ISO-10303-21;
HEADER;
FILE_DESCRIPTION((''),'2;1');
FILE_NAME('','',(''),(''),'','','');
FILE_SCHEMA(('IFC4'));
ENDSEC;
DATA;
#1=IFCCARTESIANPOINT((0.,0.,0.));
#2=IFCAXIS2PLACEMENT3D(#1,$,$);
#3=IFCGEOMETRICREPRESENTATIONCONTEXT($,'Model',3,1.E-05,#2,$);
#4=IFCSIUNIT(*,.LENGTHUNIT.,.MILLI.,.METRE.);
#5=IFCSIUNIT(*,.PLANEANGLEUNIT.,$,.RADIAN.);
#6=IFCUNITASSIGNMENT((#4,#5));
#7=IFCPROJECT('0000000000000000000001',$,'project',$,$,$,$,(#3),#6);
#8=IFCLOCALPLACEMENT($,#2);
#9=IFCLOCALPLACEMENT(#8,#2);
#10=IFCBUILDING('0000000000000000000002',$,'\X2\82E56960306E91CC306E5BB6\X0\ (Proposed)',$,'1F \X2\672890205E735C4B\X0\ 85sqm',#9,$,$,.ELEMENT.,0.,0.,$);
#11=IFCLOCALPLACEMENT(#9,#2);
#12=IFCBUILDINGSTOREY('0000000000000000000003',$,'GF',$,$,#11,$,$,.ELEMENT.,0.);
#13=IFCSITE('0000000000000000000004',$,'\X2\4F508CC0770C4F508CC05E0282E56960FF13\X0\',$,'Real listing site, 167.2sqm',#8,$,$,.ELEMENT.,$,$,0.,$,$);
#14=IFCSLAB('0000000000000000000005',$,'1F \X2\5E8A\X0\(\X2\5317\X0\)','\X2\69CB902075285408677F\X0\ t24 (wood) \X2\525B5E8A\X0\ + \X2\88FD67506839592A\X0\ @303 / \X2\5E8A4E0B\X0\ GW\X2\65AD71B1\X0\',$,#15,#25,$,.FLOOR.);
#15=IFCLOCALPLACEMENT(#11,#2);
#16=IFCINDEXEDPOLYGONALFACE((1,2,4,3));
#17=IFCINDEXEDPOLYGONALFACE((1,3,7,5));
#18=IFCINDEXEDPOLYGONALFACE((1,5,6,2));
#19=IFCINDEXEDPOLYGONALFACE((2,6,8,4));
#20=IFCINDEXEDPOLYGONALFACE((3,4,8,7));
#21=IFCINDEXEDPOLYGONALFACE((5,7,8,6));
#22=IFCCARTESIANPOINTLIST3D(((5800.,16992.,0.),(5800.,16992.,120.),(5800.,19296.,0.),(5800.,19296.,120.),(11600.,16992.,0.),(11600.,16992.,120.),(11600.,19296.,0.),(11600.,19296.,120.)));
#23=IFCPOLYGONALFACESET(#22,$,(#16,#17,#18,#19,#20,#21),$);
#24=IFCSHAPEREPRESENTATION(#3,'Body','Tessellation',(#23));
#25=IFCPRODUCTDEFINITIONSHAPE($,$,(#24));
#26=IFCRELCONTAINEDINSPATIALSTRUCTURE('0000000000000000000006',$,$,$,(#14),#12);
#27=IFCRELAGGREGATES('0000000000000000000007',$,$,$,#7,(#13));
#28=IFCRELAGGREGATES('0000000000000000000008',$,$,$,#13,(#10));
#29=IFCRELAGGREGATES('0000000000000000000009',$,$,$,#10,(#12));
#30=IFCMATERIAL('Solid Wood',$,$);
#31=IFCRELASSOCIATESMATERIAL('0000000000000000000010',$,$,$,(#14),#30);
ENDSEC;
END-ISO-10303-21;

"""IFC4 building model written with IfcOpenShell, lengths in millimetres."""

from ifc_helpers import new_model, si_unit, frame, frame_2d, origin, place, context, project, spatial, rectangle, extrude, material, element, save


model = new_model("IFC4")

# Units and contexts
model_context = context("Model", 3, precision=1e-05, world=origin())
ifc_project = project(units=[si_unit("LENGTHUNIT", "METRE", prefix="MILLI"), si_unit("PLANEANGLEUNIT", "RADIAN")], contexts=[model_context])

# Site, building, storey
site_placement = place(None, origin())
site = spatial("IfcSite", under=ifc_project, at=site_placement, Name="佐賀県佐賀市若楠３", ObjectType="Real listing site, 167.2sqm", CompositionType="ELEMENT", RefElevation=0.0)
building_placement = place(site_placement, origin())
building = spatial("IfcBuilding", under=site, at=building_placement, Name="若楠の里の家 (Proposed)", ObjectType="1F 木造平屋 85sqm", CompositionType="ELEMENT", ElevationOfRefHeight=0.0, ElevationOfTerrain=0.0)
storey_placement = place(building_placement, origin())
storey = spatial("IfcBuildingStorey", under=building, at=storey_placement, Name="GF", CompositionType="ELEMENT", Elevation=0.0)

# Slab
ifc_material_1 = material(Name="Solid Wood")
slab_1_placement = place(storey_placement, frame((2900.0, 8496.0, 0.0)))
element("IfcSlab", 1, at=slab_1_placement, inside=storey, material=ifc_material_1, Name="1F 床(北)", Description="構造用合板 t24 (wood) 剛床 + 製材根太 @303 / 床下 GW断熱", PredefinedType="FLOOR", context=model_context, shape_type="SweptSolid", body=[
    extrude(rectangle(XDim=5800.0, YDim=2304.0, at=frame_2d((2900.0, 1152.0))), frame((2900.0, 8496.0, 0.0)), (0.0, 0.0, 1.0), 120.0),
])

save(model, "model.ifc")
